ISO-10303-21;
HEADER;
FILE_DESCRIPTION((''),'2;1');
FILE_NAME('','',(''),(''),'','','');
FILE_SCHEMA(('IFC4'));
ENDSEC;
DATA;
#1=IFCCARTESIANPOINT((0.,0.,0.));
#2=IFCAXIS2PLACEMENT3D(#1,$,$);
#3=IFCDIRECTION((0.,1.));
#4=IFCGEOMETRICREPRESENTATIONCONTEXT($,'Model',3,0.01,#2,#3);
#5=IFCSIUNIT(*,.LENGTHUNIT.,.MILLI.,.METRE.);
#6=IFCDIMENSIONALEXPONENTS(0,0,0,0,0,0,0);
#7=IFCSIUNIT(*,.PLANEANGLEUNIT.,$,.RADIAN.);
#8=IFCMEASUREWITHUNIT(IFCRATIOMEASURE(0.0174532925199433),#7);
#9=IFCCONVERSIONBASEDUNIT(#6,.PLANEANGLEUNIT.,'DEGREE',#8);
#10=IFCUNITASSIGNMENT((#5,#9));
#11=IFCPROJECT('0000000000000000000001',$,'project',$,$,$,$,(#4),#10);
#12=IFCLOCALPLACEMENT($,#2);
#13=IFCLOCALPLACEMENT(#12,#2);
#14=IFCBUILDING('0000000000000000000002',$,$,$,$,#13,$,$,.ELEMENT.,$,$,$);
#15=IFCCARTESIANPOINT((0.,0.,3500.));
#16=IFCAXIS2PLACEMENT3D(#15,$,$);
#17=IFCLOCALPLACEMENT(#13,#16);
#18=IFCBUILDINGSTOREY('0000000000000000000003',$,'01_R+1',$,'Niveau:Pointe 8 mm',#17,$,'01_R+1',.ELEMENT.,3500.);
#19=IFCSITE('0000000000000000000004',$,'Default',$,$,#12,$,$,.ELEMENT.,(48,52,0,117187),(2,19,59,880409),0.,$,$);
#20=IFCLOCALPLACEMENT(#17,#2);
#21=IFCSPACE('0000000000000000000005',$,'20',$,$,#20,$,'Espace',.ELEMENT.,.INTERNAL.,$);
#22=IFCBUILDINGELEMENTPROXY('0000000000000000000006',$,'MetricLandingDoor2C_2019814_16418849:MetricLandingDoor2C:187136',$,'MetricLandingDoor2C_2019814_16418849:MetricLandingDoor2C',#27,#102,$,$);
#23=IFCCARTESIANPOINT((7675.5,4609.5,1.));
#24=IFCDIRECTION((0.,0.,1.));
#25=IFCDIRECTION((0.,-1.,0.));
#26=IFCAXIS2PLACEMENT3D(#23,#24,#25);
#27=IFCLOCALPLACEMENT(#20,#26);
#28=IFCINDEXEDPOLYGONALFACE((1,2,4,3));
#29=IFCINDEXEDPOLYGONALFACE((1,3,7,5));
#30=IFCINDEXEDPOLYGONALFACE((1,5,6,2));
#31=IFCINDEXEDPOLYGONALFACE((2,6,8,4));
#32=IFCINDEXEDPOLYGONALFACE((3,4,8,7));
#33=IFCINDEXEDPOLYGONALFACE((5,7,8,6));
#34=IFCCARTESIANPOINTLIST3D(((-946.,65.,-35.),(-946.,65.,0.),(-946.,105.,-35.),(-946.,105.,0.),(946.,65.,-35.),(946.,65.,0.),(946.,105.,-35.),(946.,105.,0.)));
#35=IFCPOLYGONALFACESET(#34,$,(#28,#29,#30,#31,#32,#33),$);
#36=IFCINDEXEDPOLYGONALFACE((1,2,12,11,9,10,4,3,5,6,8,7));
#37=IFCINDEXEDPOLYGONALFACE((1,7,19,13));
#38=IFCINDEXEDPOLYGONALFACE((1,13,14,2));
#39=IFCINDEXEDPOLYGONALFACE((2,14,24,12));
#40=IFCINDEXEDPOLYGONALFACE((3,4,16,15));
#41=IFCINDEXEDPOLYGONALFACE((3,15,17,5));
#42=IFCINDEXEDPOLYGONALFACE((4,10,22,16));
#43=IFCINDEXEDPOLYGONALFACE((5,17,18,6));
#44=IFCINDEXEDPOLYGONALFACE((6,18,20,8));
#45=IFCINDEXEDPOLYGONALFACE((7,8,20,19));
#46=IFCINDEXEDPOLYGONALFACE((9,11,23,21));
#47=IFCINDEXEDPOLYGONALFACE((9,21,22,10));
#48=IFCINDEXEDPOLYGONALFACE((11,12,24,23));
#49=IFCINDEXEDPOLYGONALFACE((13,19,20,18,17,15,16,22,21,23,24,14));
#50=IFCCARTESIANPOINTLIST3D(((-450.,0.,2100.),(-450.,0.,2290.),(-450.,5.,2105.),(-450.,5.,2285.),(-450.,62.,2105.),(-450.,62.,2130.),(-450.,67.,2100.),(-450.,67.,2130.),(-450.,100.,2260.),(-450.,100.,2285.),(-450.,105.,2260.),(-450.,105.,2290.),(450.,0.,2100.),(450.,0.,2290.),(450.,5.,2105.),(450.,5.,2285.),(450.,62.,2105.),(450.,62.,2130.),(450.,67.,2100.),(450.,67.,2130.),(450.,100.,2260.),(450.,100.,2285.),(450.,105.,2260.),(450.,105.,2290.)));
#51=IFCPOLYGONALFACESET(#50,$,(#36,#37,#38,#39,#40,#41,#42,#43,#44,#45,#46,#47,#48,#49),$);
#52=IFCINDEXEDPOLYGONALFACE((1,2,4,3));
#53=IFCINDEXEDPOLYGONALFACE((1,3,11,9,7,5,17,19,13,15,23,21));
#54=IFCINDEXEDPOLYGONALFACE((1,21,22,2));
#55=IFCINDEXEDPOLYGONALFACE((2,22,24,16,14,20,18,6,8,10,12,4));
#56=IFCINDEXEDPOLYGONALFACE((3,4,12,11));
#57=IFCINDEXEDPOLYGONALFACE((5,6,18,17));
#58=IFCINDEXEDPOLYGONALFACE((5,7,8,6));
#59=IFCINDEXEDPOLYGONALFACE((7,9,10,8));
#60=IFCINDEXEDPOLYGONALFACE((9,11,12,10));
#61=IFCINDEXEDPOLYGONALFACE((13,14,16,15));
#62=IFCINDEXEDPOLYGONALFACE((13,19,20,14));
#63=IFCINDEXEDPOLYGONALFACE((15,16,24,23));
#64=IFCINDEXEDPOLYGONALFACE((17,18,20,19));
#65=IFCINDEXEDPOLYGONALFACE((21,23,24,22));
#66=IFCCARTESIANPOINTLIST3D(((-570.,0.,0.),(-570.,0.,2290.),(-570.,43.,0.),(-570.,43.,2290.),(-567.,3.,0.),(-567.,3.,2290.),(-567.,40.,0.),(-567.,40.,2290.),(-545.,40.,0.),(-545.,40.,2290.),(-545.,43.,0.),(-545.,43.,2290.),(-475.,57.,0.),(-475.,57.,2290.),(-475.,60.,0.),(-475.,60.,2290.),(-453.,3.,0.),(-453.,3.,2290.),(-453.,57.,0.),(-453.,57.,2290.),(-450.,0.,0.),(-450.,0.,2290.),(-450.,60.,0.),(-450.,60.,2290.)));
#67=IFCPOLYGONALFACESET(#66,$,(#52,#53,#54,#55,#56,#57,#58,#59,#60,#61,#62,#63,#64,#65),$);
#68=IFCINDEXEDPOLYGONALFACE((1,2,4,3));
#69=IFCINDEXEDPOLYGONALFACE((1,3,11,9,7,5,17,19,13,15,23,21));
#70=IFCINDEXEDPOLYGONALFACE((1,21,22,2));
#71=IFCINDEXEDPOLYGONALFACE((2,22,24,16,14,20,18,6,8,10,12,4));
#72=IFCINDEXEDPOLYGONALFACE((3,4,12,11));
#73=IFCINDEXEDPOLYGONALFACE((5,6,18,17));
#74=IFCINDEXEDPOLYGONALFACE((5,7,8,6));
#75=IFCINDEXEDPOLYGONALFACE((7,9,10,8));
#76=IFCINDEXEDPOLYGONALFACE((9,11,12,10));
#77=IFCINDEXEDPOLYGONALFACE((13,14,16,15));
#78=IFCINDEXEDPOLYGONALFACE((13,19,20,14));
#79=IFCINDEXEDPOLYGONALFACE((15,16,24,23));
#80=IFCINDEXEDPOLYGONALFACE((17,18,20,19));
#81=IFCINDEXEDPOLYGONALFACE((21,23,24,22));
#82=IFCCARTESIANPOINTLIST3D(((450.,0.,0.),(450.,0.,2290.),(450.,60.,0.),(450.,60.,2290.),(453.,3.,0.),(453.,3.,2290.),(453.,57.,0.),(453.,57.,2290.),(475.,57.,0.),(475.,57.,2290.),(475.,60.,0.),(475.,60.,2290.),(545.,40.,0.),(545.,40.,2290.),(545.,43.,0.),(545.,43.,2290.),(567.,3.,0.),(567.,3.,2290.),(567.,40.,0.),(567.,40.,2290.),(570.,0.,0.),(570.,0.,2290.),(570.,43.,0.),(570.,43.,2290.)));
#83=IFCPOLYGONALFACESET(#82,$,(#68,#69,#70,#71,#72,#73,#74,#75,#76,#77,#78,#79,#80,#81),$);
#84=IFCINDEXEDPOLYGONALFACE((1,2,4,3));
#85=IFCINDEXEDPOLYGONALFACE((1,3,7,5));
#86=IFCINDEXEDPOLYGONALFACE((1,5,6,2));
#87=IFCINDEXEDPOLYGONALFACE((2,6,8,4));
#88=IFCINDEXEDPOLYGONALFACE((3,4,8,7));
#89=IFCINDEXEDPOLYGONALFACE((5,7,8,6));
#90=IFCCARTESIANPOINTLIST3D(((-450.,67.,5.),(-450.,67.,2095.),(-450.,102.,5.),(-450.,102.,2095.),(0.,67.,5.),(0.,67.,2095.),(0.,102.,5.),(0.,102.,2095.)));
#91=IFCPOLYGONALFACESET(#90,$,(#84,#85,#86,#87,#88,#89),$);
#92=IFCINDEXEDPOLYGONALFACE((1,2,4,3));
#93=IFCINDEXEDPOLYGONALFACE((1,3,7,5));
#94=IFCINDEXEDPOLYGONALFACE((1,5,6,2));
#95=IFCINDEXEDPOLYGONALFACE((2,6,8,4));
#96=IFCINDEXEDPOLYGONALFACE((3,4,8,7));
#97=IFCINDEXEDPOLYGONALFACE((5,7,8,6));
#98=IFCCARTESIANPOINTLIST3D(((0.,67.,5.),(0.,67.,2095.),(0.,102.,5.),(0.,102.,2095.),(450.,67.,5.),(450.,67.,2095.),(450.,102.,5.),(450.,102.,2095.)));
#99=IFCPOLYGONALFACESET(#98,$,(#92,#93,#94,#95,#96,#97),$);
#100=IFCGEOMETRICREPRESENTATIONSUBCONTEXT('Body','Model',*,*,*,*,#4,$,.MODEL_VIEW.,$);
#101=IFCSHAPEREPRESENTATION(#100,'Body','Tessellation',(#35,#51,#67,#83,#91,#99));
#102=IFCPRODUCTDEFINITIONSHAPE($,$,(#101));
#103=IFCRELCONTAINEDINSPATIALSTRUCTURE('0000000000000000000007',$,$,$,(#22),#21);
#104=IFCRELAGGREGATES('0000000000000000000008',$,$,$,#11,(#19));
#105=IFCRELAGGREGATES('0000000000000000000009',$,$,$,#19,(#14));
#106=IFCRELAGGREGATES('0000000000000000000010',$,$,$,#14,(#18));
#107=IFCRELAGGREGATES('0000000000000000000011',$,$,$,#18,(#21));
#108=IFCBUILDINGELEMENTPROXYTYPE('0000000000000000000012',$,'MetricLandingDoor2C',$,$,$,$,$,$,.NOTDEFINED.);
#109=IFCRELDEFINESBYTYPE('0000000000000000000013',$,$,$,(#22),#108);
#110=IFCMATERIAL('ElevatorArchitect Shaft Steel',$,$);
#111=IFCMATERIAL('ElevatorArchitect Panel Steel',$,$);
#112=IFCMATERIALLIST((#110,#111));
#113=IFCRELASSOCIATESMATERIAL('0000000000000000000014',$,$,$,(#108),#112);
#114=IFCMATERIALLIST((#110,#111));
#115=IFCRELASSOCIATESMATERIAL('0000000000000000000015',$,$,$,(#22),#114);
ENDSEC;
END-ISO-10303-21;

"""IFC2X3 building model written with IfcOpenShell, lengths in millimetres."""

from ifc_helpers import new_model, entity, si_unit, converted_unit, direction, frame, frame_2d, origin, origin_2d_with_axis, place, context, subcontext, project, spatial, polyline, rectangle, outline, extrude, source, transform, mapped, material, material_list, type_object, type_shapes, element, save


model = new_model("IFC2X3")

# Units and contexts
model_context = context("Model", 3, precision=0.01, world=origin(), true_north=direction((0.0, 1.0)))
body_context = subcontext(model_context, "Body", "Model", "MODEL_VIEW")
ifc_project = project(units=[si_unit("LENGTHUNIT", "METRE", prefix="MILLI"), converted_unit("PLANEANGLEUNIT", "DEGREE", entity("IfcRatioMeasure", 0.0174532925199433), si_unit("PLANEANGLEUNIT", "RADIAN"), dimensions=[0, 0, 0, 0, 0, 0, 0])], contexts=[model_context])

# Site, building, storey
site_placement = place(None, origin())
site = spatial("IfcSite", under=ifc_project, at=site_placement, Name="Default", CompositionType="ELEMENT", RefLatitude=(48, 52, 0, 117187), RefLongitude=(2, 19, 59, 880409), RefElevation=0.0)
building_placement = place(site_placement, origin())
building = spatial("IfcBuilding", under=site, at=building_placement, CompositionType="ELEMENT")
storey_placement = place(building_placement, frame((0.0, 0.0, 3500.0)))
storey = spatial("IfcBuildingStorey", under=building, at=storey_placement, Name="01_R+1", ObjectType="Niveau:Pointe 8 mm", LongName="01_R+1", CompositionType="ELEMENT", Elevation=3500.0)

# Shared definitions
space_placement = place(storey_placement, origin())
space = spatial("IfcSpace", under=storey, at=space_placement, Name="20", LongName="Espace", CompositionType="ELEMENT", InteriorOrExteriorSpace="INTERNAL")

# Building element proxy
ifc_material_1 = material(Name="ElevatorArchitect Shaft Steel")
ifc_material_2 = material(Name="ElevatorArchitect Panel Steel")
ifc_material_list_1 = material_list([ifc_material_1, ifc_material_2])
ifc_material_list_2 = material_list([ifc_material_1, ifc_material_2])
building_element_proxy_type = type_object("IfcBuildingElementProxyType", Name="MetricLandingDoor2C", PredefinedType="NOTDEFINED", material=ifc_material_list_2)
shared_shape = source(origin(), body_context, "Body", "SweptSolid", [
    extrude(rectangle(XDim=1892.0, YDim=40.0, at=origin_2d_with_axis()), frame((0.0, 85.0, -35.0), z_axis=(0.0, 0.0, 1.0), x_axis=(-1.0, 0.0, 0.0)), (0.0, 0.0, 1.0), 35.0),
    extrude(outline(polyline([(-48.5, -95.0), (56.5, -95.0), (56.5, 95.0), (-10.5, 95.0), (-10.5, 65.0), (-5.5, 65.0), (-5.5, 90.0), (51.5, 90.0), (51.5, -90.0), (-43.5, -90.0), (-43.5, -65.0), (-48.5, -65.0), (-48.5, -95.0)])), frame((-450.0, 56.5, 2195.0), z_axis=(1.0, 0.0, 0.0), x_axis=(0.0, -1.0, 0.0)), (0.0, 0.0, 1.0), 900.0),
    extrude(outline(polyline([(-33.8, -60.0), (26.2, -60.0), (26.2, -35.0), (23.2, -35.0), (23.2, -57.0), (-30.8, -57.0), (-30.8, 57.0), (6.2, 57.0), (6.2, 35.0), (9.2, 35.0), (9.2, 60.0), (-33.8, 60.0), (-33.8, -60.0)])), frame((-510.0, 33.8, 0.0), z_axis=(0.0, 0.0, 1.0), x_axis=(0.0, 1.0, 0.0)), (0.0, 0.0, 1.0), 2290.0),
    extrude(outline(polyline([(-60.0, -33.8), (60.0, -33.8), (60.0, 9.2), (35.0, 9.2), (35.0, 6.2), (57.0, 6.2), (57.0, -30.8), (-57.0, -30.8), (-57.0, 23.2), (-35.0, 23.2), (-35.0, 26.2), (-60.0, 26.2), (-60.0, -33.8)])), frame((510.0, 33.8, 0.0)), (0.0, 0.0, 1.0), 2290.0),
    extrude(rectangle(XDim=35.0, YDim=450.0, at=frame_2d((0.0, 0.0), x_axis=(1.0, 0.0))), frame((-225.0, 84.5, 5.0), z_axis=(0.0, 0.0, 1.0), x_axis=(0.0, -1.0, 0.0)), (0.0, 0.0, 1.0), 2090.0),
    extrude(rectangle(XDim=35.0, YDim=450.0, at=origin_2d_with_axis()), frame((225.0, 84.5, 5.0), z_axis=(0.0, 0.0, 1.0), x_axis=(0.0, -1.0, 0.0)), (0.0, 0.0, 1.0), 2090.0),
])
type_shapes(building_element_proxy_type, [shared_shape])
proxy_placement = place(space_placement, frame((7675.5, 4609.5, 1.0), z_axis=(0.0, 0.0, 1.0), x_axis=(0.0, -1.0, 0.0)))
element("IfcBuildingElementProxy", 1, at=proxy_placement, inside=space, type_object=building_element_proxy_type, material=ifc_material_list_1, Name="MetricLandingDoor2C_2019814_16418849:MetricLandingDoor2C:187136", ObjectType="MetricLandingDoor2C_2019814_16418849:MetricLandingDoor2C", context=body_context, shape_type="MappedRepresentation", body=[
    mapped(shared_shape, transform((0.0, 0.0, 0.0), scale=1.0)),
])

save(model, "model.ifc")
